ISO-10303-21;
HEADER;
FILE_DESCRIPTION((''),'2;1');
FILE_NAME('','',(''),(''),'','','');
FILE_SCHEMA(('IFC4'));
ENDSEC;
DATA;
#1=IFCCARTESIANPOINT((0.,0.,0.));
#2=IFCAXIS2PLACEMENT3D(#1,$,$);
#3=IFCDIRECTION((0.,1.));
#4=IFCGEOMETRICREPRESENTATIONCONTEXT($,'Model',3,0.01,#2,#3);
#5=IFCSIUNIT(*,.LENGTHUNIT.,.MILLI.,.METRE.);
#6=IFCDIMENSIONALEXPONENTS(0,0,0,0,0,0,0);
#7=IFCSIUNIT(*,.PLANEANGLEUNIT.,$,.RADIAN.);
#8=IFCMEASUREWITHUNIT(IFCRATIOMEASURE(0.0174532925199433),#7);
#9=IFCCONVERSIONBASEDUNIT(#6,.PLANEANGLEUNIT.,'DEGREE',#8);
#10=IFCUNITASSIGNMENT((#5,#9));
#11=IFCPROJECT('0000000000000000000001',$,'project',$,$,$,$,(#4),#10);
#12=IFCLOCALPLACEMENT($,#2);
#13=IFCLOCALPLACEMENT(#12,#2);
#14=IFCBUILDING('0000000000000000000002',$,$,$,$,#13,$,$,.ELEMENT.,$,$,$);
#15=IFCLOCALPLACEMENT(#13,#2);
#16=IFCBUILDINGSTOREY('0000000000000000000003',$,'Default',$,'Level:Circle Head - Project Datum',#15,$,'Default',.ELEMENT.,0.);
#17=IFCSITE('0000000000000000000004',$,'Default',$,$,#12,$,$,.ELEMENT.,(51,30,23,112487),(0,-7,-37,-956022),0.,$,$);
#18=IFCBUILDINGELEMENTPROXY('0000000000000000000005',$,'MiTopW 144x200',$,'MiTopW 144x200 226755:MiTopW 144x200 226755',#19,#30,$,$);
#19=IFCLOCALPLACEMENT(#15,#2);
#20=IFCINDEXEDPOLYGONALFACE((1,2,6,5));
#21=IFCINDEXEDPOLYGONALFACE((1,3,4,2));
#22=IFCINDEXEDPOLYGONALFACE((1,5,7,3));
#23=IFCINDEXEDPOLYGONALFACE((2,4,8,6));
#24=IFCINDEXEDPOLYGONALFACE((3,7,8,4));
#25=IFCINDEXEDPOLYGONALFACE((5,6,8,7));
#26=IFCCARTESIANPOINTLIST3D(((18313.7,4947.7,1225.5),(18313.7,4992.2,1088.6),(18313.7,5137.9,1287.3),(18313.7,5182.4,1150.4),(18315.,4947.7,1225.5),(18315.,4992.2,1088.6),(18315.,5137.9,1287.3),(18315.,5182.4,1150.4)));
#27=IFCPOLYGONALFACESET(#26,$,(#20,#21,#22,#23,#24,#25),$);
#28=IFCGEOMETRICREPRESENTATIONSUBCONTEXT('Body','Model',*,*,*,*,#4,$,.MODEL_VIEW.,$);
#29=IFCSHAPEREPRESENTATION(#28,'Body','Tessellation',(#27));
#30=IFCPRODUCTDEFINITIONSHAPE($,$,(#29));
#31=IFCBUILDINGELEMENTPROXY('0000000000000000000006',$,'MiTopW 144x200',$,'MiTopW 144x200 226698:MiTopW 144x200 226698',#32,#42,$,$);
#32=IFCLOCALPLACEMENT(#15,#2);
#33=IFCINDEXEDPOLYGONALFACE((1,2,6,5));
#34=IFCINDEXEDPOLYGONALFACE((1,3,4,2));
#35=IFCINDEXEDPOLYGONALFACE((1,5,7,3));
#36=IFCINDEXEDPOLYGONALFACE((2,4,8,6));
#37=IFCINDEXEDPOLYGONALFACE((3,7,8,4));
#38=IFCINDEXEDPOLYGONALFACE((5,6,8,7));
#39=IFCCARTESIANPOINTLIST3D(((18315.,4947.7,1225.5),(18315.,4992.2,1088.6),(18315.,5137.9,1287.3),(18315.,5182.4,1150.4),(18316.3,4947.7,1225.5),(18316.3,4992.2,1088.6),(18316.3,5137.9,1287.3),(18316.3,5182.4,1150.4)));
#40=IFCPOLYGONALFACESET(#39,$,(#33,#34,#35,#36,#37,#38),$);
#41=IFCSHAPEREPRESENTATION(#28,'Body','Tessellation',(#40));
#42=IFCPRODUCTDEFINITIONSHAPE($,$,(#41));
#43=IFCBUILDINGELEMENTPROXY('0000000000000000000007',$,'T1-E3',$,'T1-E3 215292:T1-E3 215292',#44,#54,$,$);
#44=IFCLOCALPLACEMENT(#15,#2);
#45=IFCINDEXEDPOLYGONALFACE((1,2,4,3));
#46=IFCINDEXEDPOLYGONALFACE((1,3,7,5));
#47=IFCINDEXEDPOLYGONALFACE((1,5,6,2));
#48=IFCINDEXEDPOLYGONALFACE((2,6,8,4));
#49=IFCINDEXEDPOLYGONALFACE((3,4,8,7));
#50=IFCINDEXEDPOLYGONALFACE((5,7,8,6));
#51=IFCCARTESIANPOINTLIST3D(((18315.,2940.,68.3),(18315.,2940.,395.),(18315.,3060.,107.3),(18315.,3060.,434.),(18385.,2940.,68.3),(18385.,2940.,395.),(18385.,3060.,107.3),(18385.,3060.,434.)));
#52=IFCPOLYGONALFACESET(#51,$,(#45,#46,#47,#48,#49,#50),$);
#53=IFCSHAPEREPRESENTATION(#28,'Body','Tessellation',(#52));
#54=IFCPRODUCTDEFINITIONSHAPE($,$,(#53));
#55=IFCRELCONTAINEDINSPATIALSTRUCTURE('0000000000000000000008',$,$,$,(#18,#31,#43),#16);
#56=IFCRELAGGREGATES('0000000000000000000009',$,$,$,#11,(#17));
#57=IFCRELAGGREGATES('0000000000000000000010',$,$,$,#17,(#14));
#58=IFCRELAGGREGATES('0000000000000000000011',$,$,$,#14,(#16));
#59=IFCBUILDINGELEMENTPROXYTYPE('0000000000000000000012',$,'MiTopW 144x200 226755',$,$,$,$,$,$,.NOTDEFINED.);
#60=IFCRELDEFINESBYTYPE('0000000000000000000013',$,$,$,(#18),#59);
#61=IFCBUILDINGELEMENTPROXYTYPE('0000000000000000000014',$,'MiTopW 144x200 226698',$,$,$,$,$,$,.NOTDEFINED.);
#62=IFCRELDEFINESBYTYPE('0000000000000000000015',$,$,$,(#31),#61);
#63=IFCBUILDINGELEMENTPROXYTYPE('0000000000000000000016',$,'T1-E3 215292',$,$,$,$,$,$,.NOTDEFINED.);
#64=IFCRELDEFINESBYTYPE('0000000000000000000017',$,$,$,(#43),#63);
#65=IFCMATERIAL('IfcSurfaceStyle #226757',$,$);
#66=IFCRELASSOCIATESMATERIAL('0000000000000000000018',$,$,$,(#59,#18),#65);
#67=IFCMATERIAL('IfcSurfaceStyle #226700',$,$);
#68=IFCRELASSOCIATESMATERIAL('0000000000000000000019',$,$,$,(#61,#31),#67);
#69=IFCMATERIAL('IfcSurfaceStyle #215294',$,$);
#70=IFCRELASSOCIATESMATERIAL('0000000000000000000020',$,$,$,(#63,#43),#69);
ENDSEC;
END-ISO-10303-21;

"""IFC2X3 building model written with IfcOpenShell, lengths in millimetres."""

from ifc_helpers import new_model, entity, si_unit, converted_unit, direction, frame, origin, place, context, subcontext, project, spatial, polyline, outline, extrude, source, transform, mapped, material, type_object, type_shapes, element, save


model = new_model("IFC2X3")

# Units and contexts
model_context = context("Model", 3, precision=0.01, world=origin(), true_north=direction((0.0, 1.0)))
body_context = subcontext(model_context, "Body", "Model", "MODEL_VIEW")
ifc_project = project(units=[si_unit("LENGTHUNIT", "METRE", prefix="MILLI"), converted_unit("PLANEANGLEUNIT", "DEGREE", entity("IfcRatioMeasure", 0.0174532925199433), si_unit("PLANEANGLEUNIT", "RADIAN"), dimensions=[0, 0, 0, 0, 0, 0, 0])], contexts=[model_context])

# Site, building, storey
site_placement = place(None, origin())
site = spatial("IfcSite", under=ifc_project, at=site_placement, Name="Default", CompositionType="ELEMENT", RefLatitude=(51, 30, 23, 112487), RefLongitude=(0, -7, -37, -956022), RefElevation=0.0)
building_placement = place(site_placement, origin())
building = spatial("IfcBuilding", under=site, at=building_placement, CompositionType="ELEMENT")
storey_placement = place(building_placement, origin())
storey = spatial("IfcBuildingStorey", under=building, at=storey_placement, Name="Default", ObjectType="Level:Circle Head - Project Datum", LongName="Default", CompositionType="ELEMENT", Elevation=0.0)

# Building element proxies
ifc_material_1 = material(Name="IfcSurfaceStyle #226757")
building_element_proxy_type_1 = type_object("IfcBuildingElementProxyType", Name="MiTopW 144x200 226755", PredefinedType="NOTDEFINED", material=ifc_material_1)
shared_shape_1 = source(origin(), body_context, "Body", "SweptSolid", [
    extrude(outline(polyline([(-100.0, -72.0), (100.0, -72.0), (100.0, 72.0), (-100.0, 72.0), (-100.0, -72.0)])), frame((100.0, 72.0, 0.0), z_axis=(0.0, 0.0, 1.0), x_axis=(-1.0, 0.0, 0.0)), (0.0, 0.0, 1.0), 1.3),
])
type_shapes(building_element_proxy_type_1, [shared_shape_1])
proxy_1_placement = place(building_placement, frame((18315.0, 4947.7, 1225.5), z_axis=(-1.0, 0.0, 0.0), x_axis=(0.0, 0.951057, 0.309017)))
element("IfcBuildingElementProxy", 1, at=proxy_1_placement, inside=storey, type_object=building_element_proxy_type_1, material=ifc_material_1, Name="MiTopW 144x200", ObjectType="MiTopW 144x200 226755:MiTopW 144x200 226755", context=body_context, shape_type="MappedRepresentation", body=[
    mapped(shared_shape_1, transform((0.0, 0.0, 0.0), scale=1.0)),
])
ifc_material_2 = material(Name="IfcSurfaceStyle #226700")
building_element_proxy_type_2 = type_object("IfcBuildingElementProxyType", Name="MiTopW 144x200 226698", PredefinedType="NOTDEFINED", material=ifc_material_2)
shared_shape_2 = source(origin(), body_context, "Body", "SweptSolid", [
    extrude(outline(polyline([(-100.0, -72.0), (100.0, -72.0), (100.0, 72.0), (-100.0, 72.0), (-100.0, -72.0)])), frame((100.0, 72.0, 0.0), z_axis=(0.0, 0.0, 1.0), x_axis=(-1.0, 0.0, 0.0)), (0.0, 0.0, 1.0), 1.3),
])
type_shapes(building_element_proxy_type_2, [shared_shape_2])
proxy_2_placement = place(building_placement, frame((18316.3, 4947.7, 1225.5), z_axis=(-1.0, 0.0, 0.0), x_axis=(0.0, 0.951057, 0.309017)))
element("IfcBuildingElementProxy", 2, at=proxy_2_placement, inside=storey, type_object=building_element_proxy_type_2, material=ifc_material_2, Name="MiTopW 144x200", ObjectType="MiTopW 144x200 226698:MiTopW 144x200 226698", context=body_context, shape_type="MappedRepresentation", body=[
    mapped(shared_shape_2, transform((0.0, 0.0, 0.0), scale=1.0)),
])
ifc_material_3 = material(Name="IfcSurfaceStyle #215294")
building_element_proxy_type_3 = type_object("IfcBuildingElementProxyType", Name="T1-E3 215292", PredefinedType="NOTDEFINED", material=ifc_material_3)
shared_shape_3 = source(origin(), body_context, "Body", "SweptSolid", [
    extrude(outline(polyline([(-182.8, -60.0), (143.8, -60.0), (182.8, 60.0), (-143.8, 60.0), (-182.8, -60.0)])), frame((182.8, 60.0, 0.0), z_axis=(0.0, 0.0, 1.0), x_axis=(-1.0, 0.0, 0.0)), (0.0, 0.0, 1.0), 70.0),
])
type_shapes(building_element_proxy_type_3, [shared_shape_3])
proxy_3_placement = place(building_placement, frame((18385.0, 2940.0, 68.3), z_axis=(-1.0, 0.0, 0.0), x_axis=(0.0, 0.0, 1.0)))
element("IfcBuildingElementProxy", 3, at=proxy_3_placement, inside=storey, type_object=building_element_proxy_type_3, material=ifc_material_3, Name="T1-E3", ObjectType="T1-E3 215292:T1-E3 215292", context=body_context, shape_type="MappedRepresentation", body=[
    mapped(shared_shape_3, transform((0.0, 0.0, 0.0), scale=1.0)),
])

save(model, "model.ifc")
